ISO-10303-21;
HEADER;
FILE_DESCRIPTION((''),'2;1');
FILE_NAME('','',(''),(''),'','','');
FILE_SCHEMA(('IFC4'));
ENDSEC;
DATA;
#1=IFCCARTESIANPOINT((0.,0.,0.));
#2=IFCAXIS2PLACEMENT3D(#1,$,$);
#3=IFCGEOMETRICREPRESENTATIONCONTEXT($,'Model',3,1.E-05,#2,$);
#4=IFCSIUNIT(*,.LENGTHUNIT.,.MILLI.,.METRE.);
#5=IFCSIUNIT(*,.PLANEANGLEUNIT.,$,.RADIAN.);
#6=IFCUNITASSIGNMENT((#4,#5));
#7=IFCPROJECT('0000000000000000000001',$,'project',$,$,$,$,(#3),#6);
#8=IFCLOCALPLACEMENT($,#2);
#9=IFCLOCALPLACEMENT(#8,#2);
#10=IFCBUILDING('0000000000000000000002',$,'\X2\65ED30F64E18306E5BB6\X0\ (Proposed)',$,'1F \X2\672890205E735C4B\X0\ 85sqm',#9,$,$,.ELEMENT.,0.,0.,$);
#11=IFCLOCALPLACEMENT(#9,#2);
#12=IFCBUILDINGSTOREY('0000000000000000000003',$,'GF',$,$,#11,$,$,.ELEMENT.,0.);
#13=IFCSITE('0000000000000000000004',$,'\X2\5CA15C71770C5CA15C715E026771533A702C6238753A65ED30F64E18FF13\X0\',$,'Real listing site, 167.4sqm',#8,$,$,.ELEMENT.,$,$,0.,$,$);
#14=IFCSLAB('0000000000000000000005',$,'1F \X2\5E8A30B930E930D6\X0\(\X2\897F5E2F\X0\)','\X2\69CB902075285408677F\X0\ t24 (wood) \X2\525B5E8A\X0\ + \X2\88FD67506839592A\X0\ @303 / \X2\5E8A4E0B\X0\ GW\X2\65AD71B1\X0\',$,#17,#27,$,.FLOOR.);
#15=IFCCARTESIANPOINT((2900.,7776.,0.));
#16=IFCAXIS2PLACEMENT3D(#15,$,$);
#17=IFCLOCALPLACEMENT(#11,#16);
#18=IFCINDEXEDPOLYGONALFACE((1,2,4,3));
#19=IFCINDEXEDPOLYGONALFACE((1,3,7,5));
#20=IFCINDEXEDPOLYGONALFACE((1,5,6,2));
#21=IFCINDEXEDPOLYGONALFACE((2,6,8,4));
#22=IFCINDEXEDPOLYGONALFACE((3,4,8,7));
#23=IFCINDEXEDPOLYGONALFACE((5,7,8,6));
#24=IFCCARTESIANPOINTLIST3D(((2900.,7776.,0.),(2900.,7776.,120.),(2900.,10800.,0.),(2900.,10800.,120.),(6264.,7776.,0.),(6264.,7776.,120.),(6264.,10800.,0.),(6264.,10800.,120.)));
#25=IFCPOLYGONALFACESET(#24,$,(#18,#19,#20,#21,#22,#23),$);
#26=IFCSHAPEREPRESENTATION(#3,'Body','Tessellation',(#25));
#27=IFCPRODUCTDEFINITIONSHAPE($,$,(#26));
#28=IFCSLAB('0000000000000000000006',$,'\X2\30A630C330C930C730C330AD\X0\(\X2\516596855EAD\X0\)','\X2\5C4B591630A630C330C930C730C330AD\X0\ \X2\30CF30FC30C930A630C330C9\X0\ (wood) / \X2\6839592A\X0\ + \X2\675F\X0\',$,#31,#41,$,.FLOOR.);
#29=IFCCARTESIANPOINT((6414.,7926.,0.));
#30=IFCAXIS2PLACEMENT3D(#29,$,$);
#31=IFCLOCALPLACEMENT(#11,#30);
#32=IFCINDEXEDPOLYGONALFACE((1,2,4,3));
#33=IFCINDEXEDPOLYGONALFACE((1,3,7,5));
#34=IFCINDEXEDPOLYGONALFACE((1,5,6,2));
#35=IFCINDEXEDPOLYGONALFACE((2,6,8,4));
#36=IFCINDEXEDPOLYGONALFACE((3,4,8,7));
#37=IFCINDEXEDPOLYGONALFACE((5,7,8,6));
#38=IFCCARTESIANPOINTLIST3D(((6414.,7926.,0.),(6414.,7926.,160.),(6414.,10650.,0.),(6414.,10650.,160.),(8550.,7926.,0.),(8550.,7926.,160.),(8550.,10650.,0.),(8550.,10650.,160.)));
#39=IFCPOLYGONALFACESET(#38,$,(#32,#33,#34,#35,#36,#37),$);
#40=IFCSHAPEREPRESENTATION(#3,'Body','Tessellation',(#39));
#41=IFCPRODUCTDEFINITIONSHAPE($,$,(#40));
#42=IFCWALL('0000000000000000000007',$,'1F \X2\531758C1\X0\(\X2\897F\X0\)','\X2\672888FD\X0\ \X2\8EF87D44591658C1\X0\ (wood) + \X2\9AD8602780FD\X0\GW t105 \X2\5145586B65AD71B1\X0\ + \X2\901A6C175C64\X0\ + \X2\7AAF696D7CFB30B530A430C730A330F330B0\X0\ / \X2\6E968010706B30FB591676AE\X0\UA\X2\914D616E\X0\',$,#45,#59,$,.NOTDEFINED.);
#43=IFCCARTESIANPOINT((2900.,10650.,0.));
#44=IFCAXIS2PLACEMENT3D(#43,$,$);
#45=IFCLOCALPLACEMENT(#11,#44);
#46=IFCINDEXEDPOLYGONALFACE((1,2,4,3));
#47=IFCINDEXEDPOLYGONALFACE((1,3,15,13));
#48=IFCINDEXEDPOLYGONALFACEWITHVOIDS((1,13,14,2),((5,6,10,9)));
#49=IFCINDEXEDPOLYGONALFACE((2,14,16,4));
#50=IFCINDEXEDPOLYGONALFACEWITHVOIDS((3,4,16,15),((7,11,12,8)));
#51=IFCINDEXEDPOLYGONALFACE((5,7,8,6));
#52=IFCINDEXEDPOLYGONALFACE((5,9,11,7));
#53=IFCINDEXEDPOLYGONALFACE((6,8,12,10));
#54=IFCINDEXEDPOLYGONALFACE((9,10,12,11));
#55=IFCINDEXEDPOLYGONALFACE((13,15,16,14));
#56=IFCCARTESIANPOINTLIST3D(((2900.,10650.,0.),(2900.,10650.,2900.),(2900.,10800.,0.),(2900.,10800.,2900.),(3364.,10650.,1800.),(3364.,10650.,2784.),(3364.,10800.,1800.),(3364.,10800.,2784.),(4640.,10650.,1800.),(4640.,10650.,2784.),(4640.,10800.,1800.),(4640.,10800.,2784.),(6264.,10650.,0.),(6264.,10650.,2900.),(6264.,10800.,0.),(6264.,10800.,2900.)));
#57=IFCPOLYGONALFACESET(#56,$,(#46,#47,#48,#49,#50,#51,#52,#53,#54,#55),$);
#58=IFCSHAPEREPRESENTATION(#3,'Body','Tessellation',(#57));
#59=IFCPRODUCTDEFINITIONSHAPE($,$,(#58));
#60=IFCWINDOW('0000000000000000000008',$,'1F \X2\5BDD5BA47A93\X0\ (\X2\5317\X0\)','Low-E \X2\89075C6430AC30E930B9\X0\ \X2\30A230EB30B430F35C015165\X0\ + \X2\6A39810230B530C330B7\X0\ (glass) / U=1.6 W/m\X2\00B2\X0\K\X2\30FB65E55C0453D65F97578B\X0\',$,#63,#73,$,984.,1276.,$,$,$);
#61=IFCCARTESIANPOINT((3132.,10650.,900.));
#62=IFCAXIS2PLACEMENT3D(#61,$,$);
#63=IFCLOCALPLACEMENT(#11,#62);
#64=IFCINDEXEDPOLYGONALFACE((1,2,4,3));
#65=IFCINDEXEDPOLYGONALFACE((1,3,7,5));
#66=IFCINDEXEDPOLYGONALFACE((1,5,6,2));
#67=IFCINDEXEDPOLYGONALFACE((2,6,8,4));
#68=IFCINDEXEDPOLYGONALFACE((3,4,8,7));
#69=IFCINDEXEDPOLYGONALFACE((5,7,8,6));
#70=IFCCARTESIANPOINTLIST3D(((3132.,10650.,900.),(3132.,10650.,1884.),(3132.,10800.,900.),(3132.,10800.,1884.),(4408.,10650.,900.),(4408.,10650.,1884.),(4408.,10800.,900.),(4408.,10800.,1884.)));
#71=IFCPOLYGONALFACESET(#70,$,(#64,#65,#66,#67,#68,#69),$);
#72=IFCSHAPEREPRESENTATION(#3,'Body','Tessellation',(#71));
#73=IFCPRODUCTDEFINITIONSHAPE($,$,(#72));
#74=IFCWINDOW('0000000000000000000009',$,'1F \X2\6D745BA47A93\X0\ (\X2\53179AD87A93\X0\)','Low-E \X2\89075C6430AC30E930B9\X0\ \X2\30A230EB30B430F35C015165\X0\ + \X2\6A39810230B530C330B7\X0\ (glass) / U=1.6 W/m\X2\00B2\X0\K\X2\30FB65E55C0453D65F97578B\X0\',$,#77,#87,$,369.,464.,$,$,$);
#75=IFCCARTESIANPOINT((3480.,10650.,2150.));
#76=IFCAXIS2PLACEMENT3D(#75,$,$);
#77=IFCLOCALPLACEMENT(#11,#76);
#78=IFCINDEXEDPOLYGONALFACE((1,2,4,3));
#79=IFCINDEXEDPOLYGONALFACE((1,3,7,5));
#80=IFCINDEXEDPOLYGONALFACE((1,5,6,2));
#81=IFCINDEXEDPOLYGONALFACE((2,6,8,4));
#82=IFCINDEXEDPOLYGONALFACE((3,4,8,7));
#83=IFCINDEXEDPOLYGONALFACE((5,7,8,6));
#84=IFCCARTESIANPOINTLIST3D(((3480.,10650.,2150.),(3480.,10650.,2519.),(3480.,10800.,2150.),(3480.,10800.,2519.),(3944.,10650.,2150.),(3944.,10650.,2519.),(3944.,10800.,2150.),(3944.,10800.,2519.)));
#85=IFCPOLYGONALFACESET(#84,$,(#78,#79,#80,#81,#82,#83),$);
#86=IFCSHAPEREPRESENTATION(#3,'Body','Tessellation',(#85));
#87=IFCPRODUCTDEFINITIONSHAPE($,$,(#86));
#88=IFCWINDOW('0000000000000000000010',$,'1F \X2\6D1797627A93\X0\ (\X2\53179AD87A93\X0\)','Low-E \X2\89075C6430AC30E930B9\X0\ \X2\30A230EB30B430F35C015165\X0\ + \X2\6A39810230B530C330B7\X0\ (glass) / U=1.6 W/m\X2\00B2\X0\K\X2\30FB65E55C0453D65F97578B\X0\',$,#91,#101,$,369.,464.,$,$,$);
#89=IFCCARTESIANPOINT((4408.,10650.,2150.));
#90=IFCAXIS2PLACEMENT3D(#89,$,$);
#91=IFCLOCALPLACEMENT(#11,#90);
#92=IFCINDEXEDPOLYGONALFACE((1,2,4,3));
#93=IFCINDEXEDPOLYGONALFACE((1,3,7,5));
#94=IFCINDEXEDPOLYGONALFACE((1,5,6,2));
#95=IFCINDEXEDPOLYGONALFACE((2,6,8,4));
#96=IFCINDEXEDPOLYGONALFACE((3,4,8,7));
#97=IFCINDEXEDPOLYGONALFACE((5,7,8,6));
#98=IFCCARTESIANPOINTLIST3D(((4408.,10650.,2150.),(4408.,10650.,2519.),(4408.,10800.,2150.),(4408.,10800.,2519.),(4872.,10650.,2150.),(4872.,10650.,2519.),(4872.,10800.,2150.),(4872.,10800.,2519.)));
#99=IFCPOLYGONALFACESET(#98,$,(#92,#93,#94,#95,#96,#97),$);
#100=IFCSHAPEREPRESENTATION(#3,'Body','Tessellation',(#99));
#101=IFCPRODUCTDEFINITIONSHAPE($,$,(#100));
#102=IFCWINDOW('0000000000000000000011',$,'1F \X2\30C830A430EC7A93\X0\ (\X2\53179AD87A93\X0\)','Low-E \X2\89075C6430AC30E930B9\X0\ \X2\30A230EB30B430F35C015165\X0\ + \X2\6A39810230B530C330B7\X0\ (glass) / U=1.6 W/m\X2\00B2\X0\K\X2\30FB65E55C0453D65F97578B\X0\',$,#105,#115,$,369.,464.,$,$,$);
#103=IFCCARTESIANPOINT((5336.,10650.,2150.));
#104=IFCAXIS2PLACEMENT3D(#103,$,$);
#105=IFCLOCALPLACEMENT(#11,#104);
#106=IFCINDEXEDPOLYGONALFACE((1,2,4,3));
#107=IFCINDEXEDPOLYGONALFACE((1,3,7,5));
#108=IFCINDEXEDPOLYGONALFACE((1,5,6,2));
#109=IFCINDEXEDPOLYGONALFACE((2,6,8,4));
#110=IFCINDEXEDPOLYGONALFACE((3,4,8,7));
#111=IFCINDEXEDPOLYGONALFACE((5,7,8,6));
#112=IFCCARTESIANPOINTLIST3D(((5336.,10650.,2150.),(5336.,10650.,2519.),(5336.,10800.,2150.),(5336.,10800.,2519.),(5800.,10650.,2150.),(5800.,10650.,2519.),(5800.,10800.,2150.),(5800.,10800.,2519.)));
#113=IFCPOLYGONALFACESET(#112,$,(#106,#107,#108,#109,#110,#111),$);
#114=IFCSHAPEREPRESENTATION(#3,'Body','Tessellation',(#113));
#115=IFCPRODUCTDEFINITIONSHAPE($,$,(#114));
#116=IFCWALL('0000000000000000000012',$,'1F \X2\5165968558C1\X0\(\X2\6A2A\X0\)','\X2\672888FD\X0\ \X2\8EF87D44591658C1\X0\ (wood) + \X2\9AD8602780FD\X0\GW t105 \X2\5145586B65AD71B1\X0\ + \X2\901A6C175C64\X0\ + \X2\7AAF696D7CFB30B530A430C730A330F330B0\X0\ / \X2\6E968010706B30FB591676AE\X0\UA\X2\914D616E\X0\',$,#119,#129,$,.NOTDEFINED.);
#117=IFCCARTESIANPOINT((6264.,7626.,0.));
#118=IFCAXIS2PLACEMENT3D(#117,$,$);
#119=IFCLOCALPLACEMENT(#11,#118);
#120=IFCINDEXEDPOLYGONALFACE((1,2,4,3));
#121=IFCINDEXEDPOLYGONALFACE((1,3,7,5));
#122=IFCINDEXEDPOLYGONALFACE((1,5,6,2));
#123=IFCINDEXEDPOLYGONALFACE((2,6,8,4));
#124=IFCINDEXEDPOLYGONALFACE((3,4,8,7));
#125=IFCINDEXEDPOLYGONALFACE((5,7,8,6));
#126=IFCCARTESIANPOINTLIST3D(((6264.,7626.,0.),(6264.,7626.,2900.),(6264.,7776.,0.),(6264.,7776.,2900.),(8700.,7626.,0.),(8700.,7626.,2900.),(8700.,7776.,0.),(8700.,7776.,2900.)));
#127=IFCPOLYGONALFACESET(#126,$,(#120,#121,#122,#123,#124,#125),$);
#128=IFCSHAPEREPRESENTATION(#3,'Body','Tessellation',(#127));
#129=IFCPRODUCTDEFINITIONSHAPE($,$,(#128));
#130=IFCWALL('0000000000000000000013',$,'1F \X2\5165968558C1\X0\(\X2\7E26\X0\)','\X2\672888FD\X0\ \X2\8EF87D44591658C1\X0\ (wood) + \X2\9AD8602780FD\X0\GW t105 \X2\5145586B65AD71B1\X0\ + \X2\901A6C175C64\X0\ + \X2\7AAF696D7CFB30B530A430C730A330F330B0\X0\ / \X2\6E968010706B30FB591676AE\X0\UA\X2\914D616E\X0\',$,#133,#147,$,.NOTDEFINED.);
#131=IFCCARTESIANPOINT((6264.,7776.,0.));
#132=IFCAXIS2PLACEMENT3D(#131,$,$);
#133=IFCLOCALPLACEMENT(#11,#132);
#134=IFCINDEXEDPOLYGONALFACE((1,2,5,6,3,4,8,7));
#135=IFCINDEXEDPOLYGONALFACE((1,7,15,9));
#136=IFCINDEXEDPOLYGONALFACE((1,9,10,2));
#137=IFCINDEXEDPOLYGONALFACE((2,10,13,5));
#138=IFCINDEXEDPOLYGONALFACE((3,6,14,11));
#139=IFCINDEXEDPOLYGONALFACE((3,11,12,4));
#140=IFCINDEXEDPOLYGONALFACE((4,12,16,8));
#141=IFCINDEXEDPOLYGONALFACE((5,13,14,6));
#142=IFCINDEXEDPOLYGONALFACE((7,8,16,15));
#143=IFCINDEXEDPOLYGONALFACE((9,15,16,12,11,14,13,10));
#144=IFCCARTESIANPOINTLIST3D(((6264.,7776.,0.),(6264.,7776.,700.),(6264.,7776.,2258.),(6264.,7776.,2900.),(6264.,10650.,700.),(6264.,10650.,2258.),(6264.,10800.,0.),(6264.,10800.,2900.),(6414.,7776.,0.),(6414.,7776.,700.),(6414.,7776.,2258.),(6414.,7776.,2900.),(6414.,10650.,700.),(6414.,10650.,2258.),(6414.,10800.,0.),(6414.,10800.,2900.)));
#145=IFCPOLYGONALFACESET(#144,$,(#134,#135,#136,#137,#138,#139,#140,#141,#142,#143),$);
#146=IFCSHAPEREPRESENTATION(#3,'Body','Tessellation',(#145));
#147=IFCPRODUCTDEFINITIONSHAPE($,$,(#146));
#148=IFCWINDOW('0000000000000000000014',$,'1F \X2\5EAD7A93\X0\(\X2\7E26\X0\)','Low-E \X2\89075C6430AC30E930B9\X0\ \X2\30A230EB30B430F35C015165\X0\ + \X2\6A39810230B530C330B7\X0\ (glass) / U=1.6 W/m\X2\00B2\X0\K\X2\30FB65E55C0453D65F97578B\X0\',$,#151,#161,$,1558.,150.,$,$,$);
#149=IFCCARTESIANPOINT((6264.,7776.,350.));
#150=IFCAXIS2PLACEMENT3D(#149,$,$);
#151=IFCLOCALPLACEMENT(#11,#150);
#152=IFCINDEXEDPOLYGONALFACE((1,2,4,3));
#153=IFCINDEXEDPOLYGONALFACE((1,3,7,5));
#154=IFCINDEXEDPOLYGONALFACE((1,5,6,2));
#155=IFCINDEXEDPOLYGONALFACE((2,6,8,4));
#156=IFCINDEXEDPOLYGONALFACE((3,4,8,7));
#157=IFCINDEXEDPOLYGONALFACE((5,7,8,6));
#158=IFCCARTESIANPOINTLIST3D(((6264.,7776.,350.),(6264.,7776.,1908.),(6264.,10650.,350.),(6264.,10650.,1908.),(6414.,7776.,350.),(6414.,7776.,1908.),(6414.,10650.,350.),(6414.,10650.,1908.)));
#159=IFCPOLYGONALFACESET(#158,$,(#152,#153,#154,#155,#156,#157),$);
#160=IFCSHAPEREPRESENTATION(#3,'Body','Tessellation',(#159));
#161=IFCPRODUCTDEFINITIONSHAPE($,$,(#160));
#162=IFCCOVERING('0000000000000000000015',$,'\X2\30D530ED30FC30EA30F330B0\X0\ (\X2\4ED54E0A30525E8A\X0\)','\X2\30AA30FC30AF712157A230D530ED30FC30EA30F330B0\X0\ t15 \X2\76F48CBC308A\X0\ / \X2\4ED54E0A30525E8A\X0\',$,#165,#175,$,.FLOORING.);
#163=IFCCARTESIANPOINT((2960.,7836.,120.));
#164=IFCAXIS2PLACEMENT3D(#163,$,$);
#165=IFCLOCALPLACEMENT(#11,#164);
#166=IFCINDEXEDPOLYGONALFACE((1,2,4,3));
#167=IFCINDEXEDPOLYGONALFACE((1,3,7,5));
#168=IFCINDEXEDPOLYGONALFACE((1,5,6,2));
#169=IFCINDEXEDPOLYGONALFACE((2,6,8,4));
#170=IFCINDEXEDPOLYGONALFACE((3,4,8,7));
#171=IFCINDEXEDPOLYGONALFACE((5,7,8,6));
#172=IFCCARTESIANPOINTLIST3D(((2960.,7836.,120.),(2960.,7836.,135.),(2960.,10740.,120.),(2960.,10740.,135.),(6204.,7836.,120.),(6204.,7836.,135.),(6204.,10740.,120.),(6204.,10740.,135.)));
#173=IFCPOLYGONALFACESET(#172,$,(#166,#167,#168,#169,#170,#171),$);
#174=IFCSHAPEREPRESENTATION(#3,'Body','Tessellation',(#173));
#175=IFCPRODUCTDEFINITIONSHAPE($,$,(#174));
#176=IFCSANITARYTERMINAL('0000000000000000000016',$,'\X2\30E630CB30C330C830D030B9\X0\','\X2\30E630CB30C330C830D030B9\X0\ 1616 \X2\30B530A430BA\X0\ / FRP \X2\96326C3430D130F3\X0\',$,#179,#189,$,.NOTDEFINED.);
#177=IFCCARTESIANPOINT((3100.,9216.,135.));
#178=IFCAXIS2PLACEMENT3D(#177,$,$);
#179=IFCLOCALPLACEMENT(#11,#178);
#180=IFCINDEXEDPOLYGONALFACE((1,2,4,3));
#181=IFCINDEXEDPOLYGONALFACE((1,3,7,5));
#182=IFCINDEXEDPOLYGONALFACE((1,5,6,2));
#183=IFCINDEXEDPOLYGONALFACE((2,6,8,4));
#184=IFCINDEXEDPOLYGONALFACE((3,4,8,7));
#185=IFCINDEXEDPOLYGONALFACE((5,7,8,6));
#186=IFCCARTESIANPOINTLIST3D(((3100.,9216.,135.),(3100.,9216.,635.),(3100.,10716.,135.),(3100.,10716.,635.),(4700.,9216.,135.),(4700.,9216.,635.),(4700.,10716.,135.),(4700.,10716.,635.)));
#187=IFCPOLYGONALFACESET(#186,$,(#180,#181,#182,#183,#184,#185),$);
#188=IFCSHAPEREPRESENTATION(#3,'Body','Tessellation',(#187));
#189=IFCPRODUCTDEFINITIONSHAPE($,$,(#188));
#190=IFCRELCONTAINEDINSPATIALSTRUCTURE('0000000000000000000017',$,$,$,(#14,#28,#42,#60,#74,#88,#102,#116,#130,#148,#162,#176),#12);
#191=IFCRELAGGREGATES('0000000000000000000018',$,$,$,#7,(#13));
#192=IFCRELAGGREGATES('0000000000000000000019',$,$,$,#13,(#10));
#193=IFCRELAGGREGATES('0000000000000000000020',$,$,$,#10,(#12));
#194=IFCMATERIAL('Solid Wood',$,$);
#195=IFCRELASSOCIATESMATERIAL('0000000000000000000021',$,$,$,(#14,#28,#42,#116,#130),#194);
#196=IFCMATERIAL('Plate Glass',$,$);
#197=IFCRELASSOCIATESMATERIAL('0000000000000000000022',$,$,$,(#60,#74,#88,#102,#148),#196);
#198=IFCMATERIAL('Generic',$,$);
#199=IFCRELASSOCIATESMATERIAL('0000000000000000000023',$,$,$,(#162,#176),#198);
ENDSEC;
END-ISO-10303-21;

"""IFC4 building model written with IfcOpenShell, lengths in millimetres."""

from ifc_helpers import new_model, si_unit, frame, frame_2d, origin, place, context, project, spatial, rectangle, extrude, material, element, fill, save


model = new_model("IFC4")

# Units and contexts
model_context = context("Model", 3, precision=1e-05, world=origin())
ifc_project = project(units=[si_unit("LENGTHUNIT", "METRE", prefix="MILLI"), si_unit("PLANEANGLEUNIT", "RADIAN")], contexts=[model_context])

# Site, building, storey
site_placement = place(None, origin())
site = spatial("IfcSite", under=ifc_project, at=site_placement, Name="岡山県岡山市東区瀬戸町旭ヶ丘３", ObjectType="Real listing site, 167.4sqm", CompositionType="ELEMENT", RefElevation=0.0)
building_placement = place(site_placement, origin())
building = spatial("IfcBuilding", under=site, at=building_placement, Name="旭ヶ丘の家 (Proposed)", ObjectType="1F 木造平屋 85sqm", CompositionType="ELEMENT", ElevationOfRefHeight=0.0, ElevationOfTerrain=0.0)
storey_placement = place(building_placement, origin())
storey = spatial("IfcBuildingStorey", under=building, at=storey_placement, Name="GF", CompositionType="ELEMENT", Elevation=0.0)

# Slabs
ifc_material_1 = material(Name="Solid Wood")
slab_1_placement = place(storey_placement, frame((2900.0, 7776.0, 0.0)))
element("IfcSlab", 1, at=slab_1_placement, inside=storey, material=ifc_material_1, Name="1F 床スラブ(西帯)", Description="構造用合板 t24 (wood) 剛床 + 製材根太 @303 / 床下 GW断熱", PredefinedType="FLOOR", context=model_context, shape_type="SweptSolid", body=[
    extrude(rectangle(XDim=3364.0, YDim=3024.0, at=frame_2d((1682.0, 1512.0))), frame((2900.0, 7776.0, 0.0)), (0.0, 0.0, 1.0), 120.0),
])
slab_2_placement = place(storey_placement, frame((6414.0, 7926.0, 0.0)))
element("IfcSlab", 2, at=slab_2_placement, inside=storey, material=ifc_material_1, Name="ウッドデッキ(入隅庭)", Description="屋外ウッドデッキ ハードウッド (wood) / 根太 + 束", PredefinedType="FLOOR", context=model_context, shape_type="SweptSolid", body=[
    extrude(rectangle(XDim=2136.0, YDim=2724.0, at=frame_2d((1068.0, 1362.0))), frame((6414.0, 7926.0, 0.0)), (0.0, 0.0, 1.0), 160.0),
])

# Wall, openings, windows
wall_1_placement = place(storey_placement, frame((2900.0, 10650.0, 0.0)))
wall_1 = element("IfcWall", 3, at=wall_1_placement, inside=storey, material=ifc_material_1, Name="1F 北壁(西)", Description="木製 軸組外壁 (wood) + 高性能GW t105 充填断熱 + 通気層 + 窯業系サイディング / 準耐火・外皮UA配慮", PredefinedType="NOTDEFINED", context=model_context, shape_type="SweptSolid", body=[
    extrude(rectangle(XDim=3364.0, YDim=150.0, at=frame_2d((1682.0, 75.0))), frame((2900.0, 10650.0, 0.0)), (0.0, 0.0, 1.0), 2900.0),
])
opening_1_placement = place(storey_placement, frame((3132.0, 10650.0, 900.0)))
opening_1 = element("IfcOpeningElement", 4, at=opening_1_placement, cuts=wall_1, PredefinedType="NOTDEFINED", context=model_context, shape_type="SweptSolid", body=[
    extrude(rectangle(XDim=1276.0, YDim=150.0, at=frame_2d((638.0, 75.0))), frame((3132.0, 10650.0, 900.0)), (0.0, 0.0, 1.0), 984.0),
])
opening_2_placement = place(storey_placement, frame((3480.0, 10650.0, 2150.0)))
opening_2 = element("IfcOpeningElement", 5, at=opening_2_placement, cuts=wall_1, PredefinedType="NOTDEFINED", context=model_context, shape_type="SweptSolid", body=[
    extrude(rectangle(XDim=464.0, YDim=150.0, at=frame_2d((232.0, 75.0))), frame((3480.0, 10650.0, 2150.0)), (0.0, 0.0, 1.0), 369.0),
])
opening_3_placement = place(storey_placement, frame((4408.0, 10650.0, 2150.0)))
opening_3 = element("IfcOpeningElement", 6, at=opening_3_placement, cuts=wall_1, PredefinedType="NOTDEFINED", context=model_context, shape_type="SweptSolid", body=[
    extrude(rectangle(XDim=464.0, YDim=150.0, at=frame_2d((232.0, 75.0))), frame((4408.0, 10650.0, 2150.0)), (0.0, 0.0, 1.0), 369.0),
])
opening_4_placement = place(storey_placement, frame((5336.0, 10650.0, 2150.0)))
opening_4 = element("IfcOpeningElement", 7, at=opening_4_placement, cuts=wall_1, PredefinedType="NOTDEFINED", context=model_context, shape_type="SweptSolid", body=[
    extrude(rectangle(XDim=464.0, YDim=150.0, at=frame_2d((232.0, 75.0))), frame((5336.0, 10650.0, 2150.0)), (0.0, 0.0, 1.0), 369.0),
])
ifc_material_2 = material(Name="Plate Glass")
window_1_placement = place(storey_placement, frame((3132.0, 10650.0, 900.0)))
window_1 = element("IfcWindow", 8, at=window_1_placement, inside=storey, material=ifc_material_2, Name="1F 寝室窓 (北)", Description="Low-E 複層ガラス アルゴン封入 + 樹脂サッシ (glass) / U=1.6 W/m²K・日射取得型", OverallHeight=984.0, OverallWidth=1276.0, context=model_context, shape_type="SweptSolid", body=[
    extrude(rectangle(XDim=1276.0, YDim=150.0, at=frame_2d((638.0, 75.0))), frame((3132.0, 10650.0, 900.0)), (0.0, 0.0, 1.0), 984.0),
])
fill(opening_1, window_1)
window_2_placement = place(storey_placement, frame((3480.0, 10650.0, 2150.0)))
window_2 = element("IfcWindow", 9, at=window_2_placement, inside=storey, material=ifc_material_2, Name="1F 浴室窓 (北高窓)", Description="Low-E 複層ガラス アルゴン封入 + 樹脂サッシ (glass) / U=1.6 W/m²K・日射取得型", OverallHeight=369.0, OverallWidth=464.0, context=model_context, shape_type="SweptSolid", body=[
    extrude(rectangle(XDim=464.0, YDim=150.0, at=frame_2d((232.0, 75.0))), frame((3480.0, 10650.0, 2150.0)), (0.0, 0.0, 1.0), 369.0),
])
fill(opening_2, window_2)
window_3_placement = place(storey_placement, frame((4408.0, 10650.0, 2150.0)))
window_3 = element("IfcWindow", 10, at=window_3_placement, inside=storey, material=ifc_material_2, Name="1F 洗面窓 (北高窓)", Description="Low-E 複層ガラス アルゴン封入 + 樹脂サッシ (glass) / U=1.6 W/m²K・日射取得型", OverallHeight=369.0, OverallWidth=464.0, context=model_context, shape_type="SweptSolid", body=[
    extrude(rectangle(XDim=464.0, YDim=150.0, at=frame_2d((232.0, 75.0))), frame((4408.0, 10650.0, 2150.0)), (0.0, 0.0, 1.0), 369.0),
])
fill(opening_3, window_3)
window_4_placement = place(storey_placement, frame((5336.0, 10650.0, 2150.0)))
window_4 = element("IfcWindow", 11, at=window_4_placement, inside=storey, material=ifc_material_2, Name="1F トイレ窓 (北高窓)", Description="Low-E 複層ガラス アルゴン封入 + 樹脂サッシ (glass) / U=1.6 W/m²K・日射取得型", OverallHeight=369.0, OverallWidth=464.0, context=model_context, shape_type="SweptSolid", body=[
    extrude(rectangle(XDim=464.0, YDim=150.0, at=frame_2d((232.0, 75.0))), frame((5336.0, 10650.0, 2150.0)), (0.0, 0.0, 1.0), 369.0),
])
fill(opening_4, window_4)

# Wall
wall_2_placement = place(storey_placement, frame((6264.0, 7626.0, 0.0)))
element("IfcWall", 12, at=wall_2_placement, inside=storey, material=ifc_material_1, Name="1F 入隅壁(横)", Description="木製 軸組外壁 (wood) + 高性能GW t105 充填断熱 + 通気層 + 窯業系サイディング / 準耐火・外皮UA配慮", PredefinedType="NOTDEFINED", context=model_context, shape_type="SweptSolid", body=[
    extrude(rectangle(XDim=2436.0, YDim=150.0, at=frame_2d((1218.0, 75.0))), frame((6264.0, 7626.0, 0.0)), (0.0, 0.0, 1.0), 2900.0),
])

# Wall, opening, window
wall_3_placement = place(storey_placement, frame((6264.0, 7776.0, 0.0)))
wall_3 = element("IfcWall", 13, at=wall_3_placement, inside=storey, material=ifc_material_1, Name="1F 入隅壁(縦)", Description="木製 軸組外壁 (wood) + 高性能GW t105 充填断熱 + 通気層 + 窯業系サイディング / 準耐火・外皮UA配慮", PredefinedType="NOTDEFINED", context=model_context, shape_type="SweptSolid", body=[
    extrude(rectangle(XDim=150.0, YDim=3024.0, at=frame_2d((75.0, 1512.0))), frame((6264.0, 7776.0, 0.0)), (0.0, 0.0, 1.0), 2900.0),
])
opening_5_placement = place(storey_placement, frame((6264.0, 7776.0, 350.0)))
opening_5 = element("IfcOpeningElement", 14, at=opening_5_placement, cuts=wall_3, PredefinedType="NOTDEFINED", context=model_context, shape_type="SweptSolid", body=[
    extrude(rectangle(XDim=150.0, YDim=2874.0, at=frame_2d((75.0, 1437.0))), frame((6264.0, 7776.0, 350.0)), (0.0, 0.0, 1.0), 1558.0),
])
window_5_placement = place(storey_placement, frame((6264.0, 7776.0, 350.0)))
window_5 = element("IfcWindow", 15, at=window_5_placement, inside=storey, material=ifc_material_2, Name="1F 庭窓(縦)", Description="Low-E 複層ガラス アルゴン封入 + 樹脂サッシ (glass) / U=1.6 W/m²K・日射取得型", OverallHeight=1558.0, OverallWidth=150.0, context=model_context, shape_type="SweptSolid", body=[
    extrude(rectangle(XDim=150.0, YDim=2874.0, at=frame_2d((75.0, 1437.0))), frame((6264.0, 7776.0, 350.0)), (0.0, 0.0, 1.0), 1558.0),
])
fill(opening_5, window_5)

# Covering
ifc_material_3 = material(Name="Generic")
covering_placement = place(storey_placement, frame((2960.0, 7836.0, 120.0)))
element("IfcCovering", 16, at=covering_placement, inside=storey, material=ifc_material_3, Name="フローリング (仕上げ床)", Description="オーク無垢フローリング t15 直貼り / 仕上げ床", PredefinedType="FLOORING", context=model_context, shape_type="SweptSolid", body=[
    extrude(rectangle(XDim=3244.0, YDim=2904.0, at=frame_2d((1622.0, 1452.0))), frame((2960.0, 7836.0, 120.0)), (0.0, 0.0, 1.0), 15.0),
])

# Sanitary terminal
sanitary_terminal_1_placement = place(storey_placement, frame((3100.0, 9216.0, 135.0)))
element("IfcSanitaryTerminal", 17, at=sanitary_terminal_1_placement, inside=storey, material=ifc_material_3, Name="ユニットバス", Description="ユニットバス 1616 サイズ / FRP 防水パン", PredefinedType="NOTDEFINED", context=model_context, shape_type="SweptSolid", body=[
    extrude(rectangle(XDim=1600.0, YDim=1500.0, at=frame_2d((800.0, 750.0))), frame((3100.0, 9216.0, 135.0)), (0.0, 0.0, 1.0), 500.0),
])

save(model, "model.ifc")
